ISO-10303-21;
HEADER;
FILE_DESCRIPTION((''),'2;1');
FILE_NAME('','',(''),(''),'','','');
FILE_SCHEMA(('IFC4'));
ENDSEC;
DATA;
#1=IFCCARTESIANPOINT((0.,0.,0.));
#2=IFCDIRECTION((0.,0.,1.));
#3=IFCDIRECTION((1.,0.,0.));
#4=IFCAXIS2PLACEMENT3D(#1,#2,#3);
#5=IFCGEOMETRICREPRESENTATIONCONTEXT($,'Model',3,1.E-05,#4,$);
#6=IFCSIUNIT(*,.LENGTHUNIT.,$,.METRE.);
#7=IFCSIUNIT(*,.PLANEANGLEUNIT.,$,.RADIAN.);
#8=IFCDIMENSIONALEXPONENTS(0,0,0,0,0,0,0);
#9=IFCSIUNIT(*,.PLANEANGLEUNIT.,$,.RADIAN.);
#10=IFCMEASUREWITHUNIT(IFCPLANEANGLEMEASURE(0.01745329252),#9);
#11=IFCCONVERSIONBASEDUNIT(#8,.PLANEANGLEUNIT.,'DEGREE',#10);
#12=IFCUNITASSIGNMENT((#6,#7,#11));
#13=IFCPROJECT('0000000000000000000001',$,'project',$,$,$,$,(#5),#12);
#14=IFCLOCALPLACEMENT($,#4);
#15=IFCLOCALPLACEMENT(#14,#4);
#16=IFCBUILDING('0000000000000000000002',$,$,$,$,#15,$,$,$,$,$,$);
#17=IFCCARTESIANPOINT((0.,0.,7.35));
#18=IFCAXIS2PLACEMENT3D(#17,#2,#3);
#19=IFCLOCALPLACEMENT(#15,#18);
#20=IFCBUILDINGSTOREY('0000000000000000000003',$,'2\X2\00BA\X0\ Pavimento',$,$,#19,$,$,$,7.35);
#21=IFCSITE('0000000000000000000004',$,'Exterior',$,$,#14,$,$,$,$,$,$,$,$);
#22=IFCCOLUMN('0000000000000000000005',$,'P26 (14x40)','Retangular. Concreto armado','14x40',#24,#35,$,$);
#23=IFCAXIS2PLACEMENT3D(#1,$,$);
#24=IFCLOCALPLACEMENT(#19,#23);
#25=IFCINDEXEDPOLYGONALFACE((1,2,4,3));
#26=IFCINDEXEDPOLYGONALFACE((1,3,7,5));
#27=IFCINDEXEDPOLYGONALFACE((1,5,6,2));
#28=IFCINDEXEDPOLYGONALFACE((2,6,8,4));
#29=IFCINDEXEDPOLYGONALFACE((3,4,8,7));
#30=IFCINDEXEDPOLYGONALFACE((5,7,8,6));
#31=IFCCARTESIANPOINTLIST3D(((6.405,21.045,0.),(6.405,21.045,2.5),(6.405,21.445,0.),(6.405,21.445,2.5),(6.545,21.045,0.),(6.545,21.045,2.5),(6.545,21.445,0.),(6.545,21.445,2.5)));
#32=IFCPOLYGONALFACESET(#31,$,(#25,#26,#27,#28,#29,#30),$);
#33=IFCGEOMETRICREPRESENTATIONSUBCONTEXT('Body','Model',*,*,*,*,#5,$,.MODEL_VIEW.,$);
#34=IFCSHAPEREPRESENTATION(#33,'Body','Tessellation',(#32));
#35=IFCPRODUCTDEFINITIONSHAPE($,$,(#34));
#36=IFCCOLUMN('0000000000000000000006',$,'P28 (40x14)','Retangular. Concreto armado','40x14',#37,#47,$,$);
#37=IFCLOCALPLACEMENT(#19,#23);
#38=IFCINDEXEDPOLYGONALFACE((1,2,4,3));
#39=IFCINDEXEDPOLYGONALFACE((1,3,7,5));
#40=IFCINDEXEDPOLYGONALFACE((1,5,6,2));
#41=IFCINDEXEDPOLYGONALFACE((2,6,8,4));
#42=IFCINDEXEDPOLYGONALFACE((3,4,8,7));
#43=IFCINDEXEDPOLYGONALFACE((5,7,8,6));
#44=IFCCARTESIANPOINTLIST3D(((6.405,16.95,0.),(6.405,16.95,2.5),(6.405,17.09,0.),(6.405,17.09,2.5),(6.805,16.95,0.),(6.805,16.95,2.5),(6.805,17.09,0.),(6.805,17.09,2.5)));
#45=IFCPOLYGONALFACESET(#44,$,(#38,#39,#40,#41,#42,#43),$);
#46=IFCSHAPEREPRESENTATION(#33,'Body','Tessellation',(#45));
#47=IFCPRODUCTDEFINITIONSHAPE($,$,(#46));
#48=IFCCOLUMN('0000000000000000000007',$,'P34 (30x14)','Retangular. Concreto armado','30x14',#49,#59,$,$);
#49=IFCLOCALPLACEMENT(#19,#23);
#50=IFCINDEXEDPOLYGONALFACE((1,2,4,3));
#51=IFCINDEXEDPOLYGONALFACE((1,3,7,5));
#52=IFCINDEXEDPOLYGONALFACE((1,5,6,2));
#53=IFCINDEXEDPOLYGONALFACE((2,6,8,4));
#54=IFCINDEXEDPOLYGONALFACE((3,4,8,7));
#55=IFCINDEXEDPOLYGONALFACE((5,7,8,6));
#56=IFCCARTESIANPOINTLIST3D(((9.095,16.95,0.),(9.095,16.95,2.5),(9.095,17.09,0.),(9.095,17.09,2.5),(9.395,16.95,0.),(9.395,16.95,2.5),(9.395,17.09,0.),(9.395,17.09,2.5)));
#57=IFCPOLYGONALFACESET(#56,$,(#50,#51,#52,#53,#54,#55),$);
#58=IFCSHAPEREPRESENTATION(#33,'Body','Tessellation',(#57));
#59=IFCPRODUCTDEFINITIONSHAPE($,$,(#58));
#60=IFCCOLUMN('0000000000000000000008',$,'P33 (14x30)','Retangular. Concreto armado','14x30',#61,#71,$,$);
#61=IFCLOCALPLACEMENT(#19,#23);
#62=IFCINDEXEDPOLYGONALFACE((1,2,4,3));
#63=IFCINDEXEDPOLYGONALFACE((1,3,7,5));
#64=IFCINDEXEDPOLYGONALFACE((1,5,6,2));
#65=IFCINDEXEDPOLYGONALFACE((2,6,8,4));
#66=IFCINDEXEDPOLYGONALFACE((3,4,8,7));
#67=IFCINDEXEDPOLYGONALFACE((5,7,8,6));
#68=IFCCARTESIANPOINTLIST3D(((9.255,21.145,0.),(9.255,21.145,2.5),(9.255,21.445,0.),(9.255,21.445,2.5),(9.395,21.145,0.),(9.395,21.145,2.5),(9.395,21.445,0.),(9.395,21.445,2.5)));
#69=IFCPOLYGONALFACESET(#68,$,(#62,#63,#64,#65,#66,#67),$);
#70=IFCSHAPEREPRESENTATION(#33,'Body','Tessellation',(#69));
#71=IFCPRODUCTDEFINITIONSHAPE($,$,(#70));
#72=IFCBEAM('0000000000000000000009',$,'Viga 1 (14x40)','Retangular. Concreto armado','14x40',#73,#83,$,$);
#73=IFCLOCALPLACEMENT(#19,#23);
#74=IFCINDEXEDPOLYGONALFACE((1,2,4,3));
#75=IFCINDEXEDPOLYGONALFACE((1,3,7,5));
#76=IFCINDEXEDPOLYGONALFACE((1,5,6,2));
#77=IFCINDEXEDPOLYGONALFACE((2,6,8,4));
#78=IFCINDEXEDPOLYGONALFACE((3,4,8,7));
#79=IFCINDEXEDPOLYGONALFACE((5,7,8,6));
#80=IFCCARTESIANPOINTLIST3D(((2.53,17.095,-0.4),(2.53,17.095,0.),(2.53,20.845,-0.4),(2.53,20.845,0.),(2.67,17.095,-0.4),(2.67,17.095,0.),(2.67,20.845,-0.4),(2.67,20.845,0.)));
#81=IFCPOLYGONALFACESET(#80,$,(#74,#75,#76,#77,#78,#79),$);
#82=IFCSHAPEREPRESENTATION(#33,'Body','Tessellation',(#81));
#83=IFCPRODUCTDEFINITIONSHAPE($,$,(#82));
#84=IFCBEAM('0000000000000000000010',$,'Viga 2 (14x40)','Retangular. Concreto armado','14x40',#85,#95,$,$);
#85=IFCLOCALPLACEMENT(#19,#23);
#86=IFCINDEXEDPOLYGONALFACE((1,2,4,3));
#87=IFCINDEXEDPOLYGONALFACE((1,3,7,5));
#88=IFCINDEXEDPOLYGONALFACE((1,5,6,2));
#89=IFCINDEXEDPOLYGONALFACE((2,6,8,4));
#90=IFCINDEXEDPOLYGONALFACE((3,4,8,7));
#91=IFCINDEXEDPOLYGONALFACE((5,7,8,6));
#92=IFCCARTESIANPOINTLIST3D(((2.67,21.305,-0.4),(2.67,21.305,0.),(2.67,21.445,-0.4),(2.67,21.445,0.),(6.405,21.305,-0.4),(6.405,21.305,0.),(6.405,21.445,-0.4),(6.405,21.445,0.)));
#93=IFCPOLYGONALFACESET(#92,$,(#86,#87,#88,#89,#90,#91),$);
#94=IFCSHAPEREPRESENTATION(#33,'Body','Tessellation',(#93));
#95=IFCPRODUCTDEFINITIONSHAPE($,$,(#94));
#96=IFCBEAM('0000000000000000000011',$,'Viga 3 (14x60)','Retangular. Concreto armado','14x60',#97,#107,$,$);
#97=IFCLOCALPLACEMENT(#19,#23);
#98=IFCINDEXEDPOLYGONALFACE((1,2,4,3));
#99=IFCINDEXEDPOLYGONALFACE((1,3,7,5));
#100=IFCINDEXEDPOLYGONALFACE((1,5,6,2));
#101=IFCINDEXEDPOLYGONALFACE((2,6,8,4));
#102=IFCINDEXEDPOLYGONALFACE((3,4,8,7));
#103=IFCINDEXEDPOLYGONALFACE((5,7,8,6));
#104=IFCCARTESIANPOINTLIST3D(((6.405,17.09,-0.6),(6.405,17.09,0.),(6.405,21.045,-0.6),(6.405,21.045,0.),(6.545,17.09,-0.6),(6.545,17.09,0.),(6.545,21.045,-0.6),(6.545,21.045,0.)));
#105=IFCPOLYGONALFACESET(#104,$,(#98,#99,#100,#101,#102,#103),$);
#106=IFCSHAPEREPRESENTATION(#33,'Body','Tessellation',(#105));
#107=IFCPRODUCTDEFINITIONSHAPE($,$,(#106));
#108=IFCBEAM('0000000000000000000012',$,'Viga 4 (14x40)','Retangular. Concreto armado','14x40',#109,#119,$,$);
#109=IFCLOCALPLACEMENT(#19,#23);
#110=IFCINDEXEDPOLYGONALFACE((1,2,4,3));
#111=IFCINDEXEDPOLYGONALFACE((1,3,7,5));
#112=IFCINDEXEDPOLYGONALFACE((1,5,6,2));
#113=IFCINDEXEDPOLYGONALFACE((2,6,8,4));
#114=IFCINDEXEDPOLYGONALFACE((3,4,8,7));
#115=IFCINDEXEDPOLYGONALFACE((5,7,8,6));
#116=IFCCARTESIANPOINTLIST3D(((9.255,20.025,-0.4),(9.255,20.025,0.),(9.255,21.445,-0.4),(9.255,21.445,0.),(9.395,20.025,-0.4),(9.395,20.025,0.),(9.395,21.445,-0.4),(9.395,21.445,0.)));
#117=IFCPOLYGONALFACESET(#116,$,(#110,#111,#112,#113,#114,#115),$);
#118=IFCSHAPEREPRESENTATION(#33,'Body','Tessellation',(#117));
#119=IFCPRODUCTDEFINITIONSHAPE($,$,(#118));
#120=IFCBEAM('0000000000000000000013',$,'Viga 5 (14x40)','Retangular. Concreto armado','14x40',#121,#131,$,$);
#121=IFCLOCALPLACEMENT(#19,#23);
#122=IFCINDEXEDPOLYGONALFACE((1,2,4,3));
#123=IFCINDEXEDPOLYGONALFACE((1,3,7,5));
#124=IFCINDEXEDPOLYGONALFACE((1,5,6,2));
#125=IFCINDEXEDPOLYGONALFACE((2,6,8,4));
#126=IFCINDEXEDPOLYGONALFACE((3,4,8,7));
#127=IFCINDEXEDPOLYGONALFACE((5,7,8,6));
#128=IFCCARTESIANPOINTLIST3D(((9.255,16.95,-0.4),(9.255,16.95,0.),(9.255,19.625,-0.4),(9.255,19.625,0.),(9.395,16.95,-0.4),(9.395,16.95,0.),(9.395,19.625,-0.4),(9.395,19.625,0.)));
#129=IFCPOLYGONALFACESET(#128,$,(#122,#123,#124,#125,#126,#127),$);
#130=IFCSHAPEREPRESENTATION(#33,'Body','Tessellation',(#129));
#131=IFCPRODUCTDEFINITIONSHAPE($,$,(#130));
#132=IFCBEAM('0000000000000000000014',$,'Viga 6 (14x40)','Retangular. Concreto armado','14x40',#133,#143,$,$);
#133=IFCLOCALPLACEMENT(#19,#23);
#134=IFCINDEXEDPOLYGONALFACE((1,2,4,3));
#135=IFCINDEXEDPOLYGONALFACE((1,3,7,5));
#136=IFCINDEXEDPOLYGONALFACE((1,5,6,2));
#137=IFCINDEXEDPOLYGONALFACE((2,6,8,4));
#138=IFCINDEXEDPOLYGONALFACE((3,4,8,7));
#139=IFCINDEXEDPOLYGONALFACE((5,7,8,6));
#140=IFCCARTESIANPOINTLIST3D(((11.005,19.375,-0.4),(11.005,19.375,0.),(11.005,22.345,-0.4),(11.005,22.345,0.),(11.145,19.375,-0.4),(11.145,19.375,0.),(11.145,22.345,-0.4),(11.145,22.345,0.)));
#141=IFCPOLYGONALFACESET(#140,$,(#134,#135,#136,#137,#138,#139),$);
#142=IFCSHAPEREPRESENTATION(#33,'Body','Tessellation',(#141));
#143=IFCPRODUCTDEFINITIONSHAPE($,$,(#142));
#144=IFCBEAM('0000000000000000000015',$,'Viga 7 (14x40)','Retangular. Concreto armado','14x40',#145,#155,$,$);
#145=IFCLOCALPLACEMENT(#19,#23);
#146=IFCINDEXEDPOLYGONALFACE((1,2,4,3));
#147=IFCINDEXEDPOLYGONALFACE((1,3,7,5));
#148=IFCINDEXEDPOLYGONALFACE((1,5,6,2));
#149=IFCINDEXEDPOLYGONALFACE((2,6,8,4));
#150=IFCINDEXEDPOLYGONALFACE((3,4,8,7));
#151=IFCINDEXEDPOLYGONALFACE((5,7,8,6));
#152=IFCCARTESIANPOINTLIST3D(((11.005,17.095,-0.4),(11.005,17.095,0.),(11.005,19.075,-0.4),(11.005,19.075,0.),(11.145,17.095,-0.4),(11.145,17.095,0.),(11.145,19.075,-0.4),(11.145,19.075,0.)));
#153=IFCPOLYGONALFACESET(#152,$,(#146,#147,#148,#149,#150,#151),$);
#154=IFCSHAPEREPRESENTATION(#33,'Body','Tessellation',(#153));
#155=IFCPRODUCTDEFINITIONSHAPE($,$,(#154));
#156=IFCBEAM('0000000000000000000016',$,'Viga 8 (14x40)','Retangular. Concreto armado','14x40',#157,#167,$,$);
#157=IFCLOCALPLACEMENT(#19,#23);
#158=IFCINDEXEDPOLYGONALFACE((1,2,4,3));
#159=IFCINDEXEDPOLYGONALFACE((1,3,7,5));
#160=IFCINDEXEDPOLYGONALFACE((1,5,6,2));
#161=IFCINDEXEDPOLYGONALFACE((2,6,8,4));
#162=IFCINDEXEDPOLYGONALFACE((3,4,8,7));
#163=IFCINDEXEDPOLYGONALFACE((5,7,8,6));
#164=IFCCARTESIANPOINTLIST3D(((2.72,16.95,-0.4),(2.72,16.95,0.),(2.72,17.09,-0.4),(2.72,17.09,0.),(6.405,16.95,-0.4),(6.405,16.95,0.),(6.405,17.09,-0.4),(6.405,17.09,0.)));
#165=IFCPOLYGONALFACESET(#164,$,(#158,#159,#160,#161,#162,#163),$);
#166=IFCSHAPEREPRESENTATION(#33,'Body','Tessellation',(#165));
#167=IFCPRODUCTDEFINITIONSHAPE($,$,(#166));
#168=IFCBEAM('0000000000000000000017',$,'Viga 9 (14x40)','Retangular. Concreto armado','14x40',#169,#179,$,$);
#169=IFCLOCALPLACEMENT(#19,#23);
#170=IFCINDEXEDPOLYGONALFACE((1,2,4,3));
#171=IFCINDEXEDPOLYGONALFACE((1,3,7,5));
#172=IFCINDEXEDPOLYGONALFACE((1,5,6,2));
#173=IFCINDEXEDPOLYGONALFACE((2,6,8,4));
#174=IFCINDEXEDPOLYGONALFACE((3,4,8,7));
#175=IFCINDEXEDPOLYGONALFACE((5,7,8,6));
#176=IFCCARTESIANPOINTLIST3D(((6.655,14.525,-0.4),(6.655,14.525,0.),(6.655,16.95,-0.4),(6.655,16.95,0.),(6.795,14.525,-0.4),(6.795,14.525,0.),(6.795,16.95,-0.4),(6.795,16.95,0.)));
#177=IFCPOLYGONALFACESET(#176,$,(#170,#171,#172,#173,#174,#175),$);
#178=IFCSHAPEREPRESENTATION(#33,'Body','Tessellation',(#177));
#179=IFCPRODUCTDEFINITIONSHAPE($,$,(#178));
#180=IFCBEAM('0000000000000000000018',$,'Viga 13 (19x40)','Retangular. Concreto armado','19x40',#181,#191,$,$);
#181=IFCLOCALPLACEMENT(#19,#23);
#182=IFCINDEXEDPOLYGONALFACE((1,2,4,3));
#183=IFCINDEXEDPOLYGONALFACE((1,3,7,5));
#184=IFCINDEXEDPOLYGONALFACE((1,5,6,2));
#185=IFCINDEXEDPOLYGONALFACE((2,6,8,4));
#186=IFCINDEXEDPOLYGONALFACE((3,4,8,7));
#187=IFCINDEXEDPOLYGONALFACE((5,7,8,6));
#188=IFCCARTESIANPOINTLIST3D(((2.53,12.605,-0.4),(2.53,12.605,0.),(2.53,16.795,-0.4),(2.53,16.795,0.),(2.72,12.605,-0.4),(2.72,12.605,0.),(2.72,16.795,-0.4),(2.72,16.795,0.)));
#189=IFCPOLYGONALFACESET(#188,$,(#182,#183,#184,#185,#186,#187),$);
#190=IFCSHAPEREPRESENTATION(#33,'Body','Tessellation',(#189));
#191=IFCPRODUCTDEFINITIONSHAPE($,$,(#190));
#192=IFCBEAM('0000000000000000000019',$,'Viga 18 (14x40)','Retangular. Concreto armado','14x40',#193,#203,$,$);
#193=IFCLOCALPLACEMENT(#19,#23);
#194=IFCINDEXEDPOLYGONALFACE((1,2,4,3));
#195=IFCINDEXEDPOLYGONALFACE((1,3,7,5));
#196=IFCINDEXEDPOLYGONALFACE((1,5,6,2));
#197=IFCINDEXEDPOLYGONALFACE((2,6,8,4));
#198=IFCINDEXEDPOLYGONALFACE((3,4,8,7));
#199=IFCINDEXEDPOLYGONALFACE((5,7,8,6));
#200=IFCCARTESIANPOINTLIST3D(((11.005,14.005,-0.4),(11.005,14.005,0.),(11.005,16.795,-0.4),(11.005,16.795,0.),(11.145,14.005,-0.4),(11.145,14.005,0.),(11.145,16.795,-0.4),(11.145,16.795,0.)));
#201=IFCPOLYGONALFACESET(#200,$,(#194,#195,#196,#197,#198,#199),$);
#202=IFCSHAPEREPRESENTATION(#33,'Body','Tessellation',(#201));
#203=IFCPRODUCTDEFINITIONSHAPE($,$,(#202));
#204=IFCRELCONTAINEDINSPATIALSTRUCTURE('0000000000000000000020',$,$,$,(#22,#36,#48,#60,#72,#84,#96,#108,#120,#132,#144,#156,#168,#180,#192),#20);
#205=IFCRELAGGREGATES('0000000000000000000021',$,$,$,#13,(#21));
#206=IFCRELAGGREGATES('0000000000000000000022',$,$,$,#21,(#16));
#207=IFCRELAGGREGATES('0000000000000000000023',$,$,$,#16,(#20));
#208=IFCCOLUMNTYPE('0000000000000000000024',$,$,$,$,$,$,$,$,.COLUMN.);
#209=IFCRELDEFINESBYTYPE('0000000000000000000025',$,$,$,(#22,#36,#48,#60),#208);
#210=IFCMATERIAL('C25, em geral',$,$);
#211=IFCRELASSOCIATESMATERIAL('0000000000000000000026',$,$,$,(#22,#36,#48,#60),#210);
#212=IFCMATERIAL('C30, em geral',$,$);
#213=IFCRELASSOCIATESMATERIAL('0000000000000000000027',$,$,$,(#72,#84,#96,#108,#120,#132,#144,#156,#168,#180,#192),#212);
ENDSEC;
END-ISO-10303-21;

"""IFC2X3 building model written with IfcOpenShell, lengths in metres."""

from ifc_helpers import new_model, entity, si_unit, converted_unit, frame, frame_2d, origin_with_axes, place, context, subcontext, project, spatial, rectangle, extrude, material, type_object, element, save


model = new_model("IFC2X3")

# Units and contexts
model_context = context("Model", 3, precision=1e-05, world=origin_with_axes())
body_context = subcontext(model_context, "Body", "Model", "MODEL_VIEW")
ifc_project = project(units=[si_unit("LENGTHUNIT", "METRE"), si_unit("PLANEANGLEUNIT", "RADIAN"), converted_unit("PLANEANGLEUNIT", "DEGREE", entity("IfcPlaneAngleMeasure", 0.01745329252), si_unit("PLANEANGLEUNIT", "RADIAN"), dimensions=[0, 0, 0, 0, 0, 0, 0])], contexts=[model_context])

# Site, building, storey
site_placement = place(None, origin_with_axes())
site = spatial("IfcSite", under=ifc_project, at=site_placement, Name="Exterior")
building_placement = place(site_placement, origin_with_axes())
building = spatial("IfcBuilding", under=site, at=building_placement)
storey_placement = place(building_placement, frame((0.0, 0.0, 7.35), z_axis=(0.0, 0.0, 1.0), x_axis=(1.0, 0.0, 0.0)))
storey = spatial("IfcBuildingStorey", under=building, at=storey_placement, Name="2º Pavimento", Elevation=7.35)

# Columns
ifc_material_1 = material(Name="C25, em geral")
column_type = type_object("IfcColumnType", PredefinedType="COLUMN")
column_1_placement = place(storey_placement, frame((6.545, 21.445, 0.0), z_axis=(0.0, 0.0, 1.0), x_axis=(1.0, 0.0, 0.0)))
element("IfcColumn", 1, at=column_1_placement, inside=storey, type_object=column_type, material=ifc_material_1, Name="P26 (14x40)", Description="Retangular. Concreto armado", ObjectType="14x40", context=body_context, shape_type="SweptSolid", body=[
    extrude(rectangle(XDim=0.14, YDim=0.4, at=frame_2d((-0.07, -0.2), x_axis=(1.0, 0.0))), origin_with_axes(), (0.0, 0.0, 1.0), 2.5),
])
column_2_placement = place(storey_placement, frame((6.405, 16.95, 0.0), z_axis=(0.0, 0.0, 1.0), x_axis=(1.0, 0.0, 0.0)))
element("IfcColumn", 2, at=column_2_placement, inside=storey, type_object=column_type, material=ifc_material_1, Name="P28 (40x14)", Description="Retangular. Concreto armado", ObjectType="40x14", context=body_context, shape_type="SweptSolid", body=[
    extrude(rectangle(XDim=0.4, YDim=0.14, at=frame_2d((0.2, 0.07), x_axis=(1.0, 0.0))), origin_with_axes(), (0.0, 0.0, 1.0), 2.5),
])
column_3_placement = place(storey_placement, frame((9.395, 16.95, 0.0), z_axis=(0.0, 0.0, 1.0), x_axis=(1.0, 0.0, 0.0)))
element("IfcColumn", 3, at=column_3_placement, inside=storey, type_object=column_type, material=ifc_material_1, Name="P34 (30x14)", Description="Retangular. Concreto armado", ObjectType="30x14", context=body_context, shape_type="SweptSolid", body=[
    extrude(rectangle(XDim=0.3, YDim=0.14, at=frame_2d((-0.15, 0.07), x_axis=(1.0, 0.0))), origin_with_axes(), (0.0, 0.0, 1.0), 2.5),
])
column_4_placement = place(storey_placement, frame((9.395, 21.445, 0.0), z_axis=(0.0, 0.0, 1.0), x_axis=(1.0, 0.0, 0.0)))
element("IfcColumn", 4, at=column_4_placement, inside=storey, type_object=column_type, material=ifc_material_1, Name="P33 (14x30)", Description="Retangular. Concreto armado", ObjectType="14x30", context=body_context, shape_type="SweptSolid", body=[
    extrude(rectangle(XDim=0.14, YDim=0.3, at=frame_2d((-0.07, -0.15), x_axis=(1.0, 0.0))), origin_with_axes(), (0.0, 0.0, 1.0), 2.5),
])

# Beams
ifc_material_2 = material(Name="C30, em geral")
beam_1_placement = place(storey_placement, frame((2.6, 20.845, 0.0), z_axis=(0.0, -1.0, 0.0), x_axis=(1.0, 0.0, 0.0)))
element("IfcBeam", 5, at=beam_1_placement, inside=storey, material=ifc_material_2, Name="Viga 1 (14x40)", Description="Retangular. Concreto armado", ObjectType="14x40", context=body_context, shape_type="SweptSolid", body=[
    extrude(rectangle(XDim=0.14, YDim=0.4, at=frame_2d((0.0, -0.2), x_axis=(1.0, 0.0))), origin_with_axes(), (0.0, 0.0, 1.0), 3.75),
])
beam_2_placement = place(storey_placement, frame((2.67, 21.375, 0.0), z_axis=(1.0, 0.0, 0.0), x_axis=(0.0, 1.0, 0.0)))
element("IfcBeam", 6, at=beam_2_placement, inside=storey, material=ifc_material_2, Name="Viga 2 (14x40)", Description="Retangular. Concreto armado", ObjectType="14x40", context=body_context, shape_type="SweptSolid", body=[
    extrude(rectangle(XDim=0.14, YDim=0.4, at=frame_2d((0.0, -0.2), x_axis=(1.0, 0.0))), origin_with_axes(), (0.0, 0.0, 1.0), 3.735),
])
beam_3_placement = place(storey_placement, frame((6.475, 21.045, 0.0), z_axis=(0.0, -1.0, 0.0), x_axis=(1.0, 0.0, 0.0)))
element("IfcBeam", 7, at=beam_3_placement, inside=storey, material=ifc_material_2, Name="Viga 3 (14x60)", Description="Retangular. Concreto armado", ObjectType="14x60", context=body_context, shape_type="SweptSolid", body=[
    extrude(rectangle(XDim=0.14, YDim=0.6, at=frame_2d((0.0, -0.3), x_axis=(1.0, 0.0))), origin_with_axes(), (0.0, 0.0, 1.0), 3.955),
])
beam_4_placement = place(storey_placement, frame((9.325, 20.025, 0.0), z_axis=(0.0, 1.0, 0.0), x_axis=(-1.0, 0.0, 0.0)))
element("IfcBeam", 8, at=beam_4_placement, inside=storey, material=ifc_material_2, Name="Viga 4 (14x40)", Description="Retangular. Concreto armado", ObjectType="14x40", context=body_context, shape_type="SweptSolid", body=[
    extrude(rectangle(XDim=0.14, YDim=0.4, at=frame_2d((0.0, -0.2), x_axis=(1.0, 0.0))), origin_with_axes(), (0.0, 0.0, 1.0), 1.42),
])
beam_5_placement = place(storey_placement, frame((9.325, 19.625, 0.0), z_axis=(0.0, -1.0, 0.0), x_axis=(1.0, 0.0, 0.0)))
element("IfcBeam", 9, at=beam_5_placement, inside=storey, material=ifc_material_2, Name="Viga 5 (14x40)", Description="Retangular. Concreto armado", ObjectType="14x40", context=body_context, shape_type="SweptSolid", body=[
    extrude(rectangle(XDim=0.14, YDim=0.4, at=frame_2d((0.0, -0.2), x_axis=(1.0, 0.0))), origin_with_axes(), (0.0, 0.0, 1.0), 2.675),
])
beam_6_placement = place(storey_placement, frame((11.075, 22.345, 0.0), z_axis=(0.0, -1.0, 0.0), x_axis=(1.0, 0.0, 0.0)))
element("IfcBeam", 10, at=beam_6_placement, inside=storey, material=ifc_material_2, Name="Viga 6 (14x40)", Description="Retangular. Concreto armado", ObjectType="14x40", context=body_context, shape_type="SweptSolid", body=[
    extrude(rectangle(XDim=0.14, YDim=0.4, at=frame_2d((0.0, -0.2), x_axis=(1.0, 0.0))), origin_with_axes(), (0.0, 0.0, 1.0), 2.97),
])
beam_7_placement = place(storey_placement, frame((11.075, 19.075, 0.0), z_axis=(0.0, -1.0, 0.0), x_axis=(1.0, 0.0, 0.0)))
element("IfcBeam", 11, at=beam_7_placement, inside=storey, material=ifc_material_2, Name="Viga 7 (14x40)", Description="Retangular. Concreto armado", ObjectType="14x40", context=body_context, shape_type="SweptSolid", body=[
    extrude(rectangle(XDim=0.14, YDim=0.4, at=frame_2d((0.0, -0.2), x_axis=(1.0, 0.0))), origin_with_axes(), (0.0, 0.0, 1.0), 1.98),
])
beam_8_placement = place(storey_placement, frame((6.405, 17.02, 0.0), z_axis=(-1.0, 0.0, 0.0), x_axis=(0.0, -1.0, 0.0)))
element("IfcBeam", 12, at=beam_8_placement, inside=storey, material=ifc_material_2, Name="Viga 8 (14x40)", Description="Retangular. Concreto armado", ObjectType="14x40", context=body_context, shape_type="SweptSolid", body=[
    extrude(rectangle(XDim=0.14, YDim=0.4, at=frame_2d((0.0, -0.2), x_axis=(1.0, 0.0))), origin_with_axes(), (0.0, 0.0, 1.0), 3.685),
])
beam_9_placement = place(storey_placement, frame((6.725, 14.525, 0.0), z_axis=(0.0, 1.0, 0.0), x_axis=(-1.0, 0.0, 0.0)))
element("IfcBeam", 13, at=beam_9_placement, inside=storey, material=ifc_material_2, Name="Viga 9 (14x40)", Description="Retangular. Concreto armado", ObjectType="14x40", context=body_context, shape_type="SweptSolid", body=[
    extrude(rectangle(XDim=0.14, YDim=0.4, at=frame_2d((0.0, -0.2), x_axis=(1.0, 0.0))), origin_with_axes(), (0.0, 0.0, 1.0), 2.425),
])
beam_10_placement = place(storey_placement, frame((2.625, 16.795, 0.0), z_axis=(0.0, -1.0, 0.0), x_axis=(1.0, 0.0, 0.0)))
element("IfcBeam", 14, at=beam_10_placement, inside=storey, material=ifc_material_2, Name="Viga 13 (19x40)", Description="Retangular. Concreto armado", ObjectType="19x40", context=body_context, shape_type="SweptSolid", body=[
    extrude(rectangle(XDim=0.19, YDim=0.4, at=frame_2d((0.0, -0.2), x_axis=(1.0, 0.0))), origin_with_axes(), (0.0, 0.0, 1.0), 4.19),
])
beam_11_placement = place(storey_placement, frame((11.075, 14.005, 0.0), z_axis=(0.0, 1.0, 0.0), x_axis=(-1.0, 0.0, 0.0)))
element("IfcBeam", 15, at=beam_11_placement, inside=storey, material=ifc_material_2, Name="Viga 18 (14x40)", Description="Retangular. Concreto armado", ObjectType="14x40", context=body_context, shape_type="SweptSolid", body=[
    extrude(rectangle(XDim=0.14, YDim=0.4, at=frame_2d((0.0, -0.2), x_axis=(1.0, 0.0))), origin_with_axes(), (0.0, 0.0, 1.0), 2.79),
])

save(model, "model.ifc")
